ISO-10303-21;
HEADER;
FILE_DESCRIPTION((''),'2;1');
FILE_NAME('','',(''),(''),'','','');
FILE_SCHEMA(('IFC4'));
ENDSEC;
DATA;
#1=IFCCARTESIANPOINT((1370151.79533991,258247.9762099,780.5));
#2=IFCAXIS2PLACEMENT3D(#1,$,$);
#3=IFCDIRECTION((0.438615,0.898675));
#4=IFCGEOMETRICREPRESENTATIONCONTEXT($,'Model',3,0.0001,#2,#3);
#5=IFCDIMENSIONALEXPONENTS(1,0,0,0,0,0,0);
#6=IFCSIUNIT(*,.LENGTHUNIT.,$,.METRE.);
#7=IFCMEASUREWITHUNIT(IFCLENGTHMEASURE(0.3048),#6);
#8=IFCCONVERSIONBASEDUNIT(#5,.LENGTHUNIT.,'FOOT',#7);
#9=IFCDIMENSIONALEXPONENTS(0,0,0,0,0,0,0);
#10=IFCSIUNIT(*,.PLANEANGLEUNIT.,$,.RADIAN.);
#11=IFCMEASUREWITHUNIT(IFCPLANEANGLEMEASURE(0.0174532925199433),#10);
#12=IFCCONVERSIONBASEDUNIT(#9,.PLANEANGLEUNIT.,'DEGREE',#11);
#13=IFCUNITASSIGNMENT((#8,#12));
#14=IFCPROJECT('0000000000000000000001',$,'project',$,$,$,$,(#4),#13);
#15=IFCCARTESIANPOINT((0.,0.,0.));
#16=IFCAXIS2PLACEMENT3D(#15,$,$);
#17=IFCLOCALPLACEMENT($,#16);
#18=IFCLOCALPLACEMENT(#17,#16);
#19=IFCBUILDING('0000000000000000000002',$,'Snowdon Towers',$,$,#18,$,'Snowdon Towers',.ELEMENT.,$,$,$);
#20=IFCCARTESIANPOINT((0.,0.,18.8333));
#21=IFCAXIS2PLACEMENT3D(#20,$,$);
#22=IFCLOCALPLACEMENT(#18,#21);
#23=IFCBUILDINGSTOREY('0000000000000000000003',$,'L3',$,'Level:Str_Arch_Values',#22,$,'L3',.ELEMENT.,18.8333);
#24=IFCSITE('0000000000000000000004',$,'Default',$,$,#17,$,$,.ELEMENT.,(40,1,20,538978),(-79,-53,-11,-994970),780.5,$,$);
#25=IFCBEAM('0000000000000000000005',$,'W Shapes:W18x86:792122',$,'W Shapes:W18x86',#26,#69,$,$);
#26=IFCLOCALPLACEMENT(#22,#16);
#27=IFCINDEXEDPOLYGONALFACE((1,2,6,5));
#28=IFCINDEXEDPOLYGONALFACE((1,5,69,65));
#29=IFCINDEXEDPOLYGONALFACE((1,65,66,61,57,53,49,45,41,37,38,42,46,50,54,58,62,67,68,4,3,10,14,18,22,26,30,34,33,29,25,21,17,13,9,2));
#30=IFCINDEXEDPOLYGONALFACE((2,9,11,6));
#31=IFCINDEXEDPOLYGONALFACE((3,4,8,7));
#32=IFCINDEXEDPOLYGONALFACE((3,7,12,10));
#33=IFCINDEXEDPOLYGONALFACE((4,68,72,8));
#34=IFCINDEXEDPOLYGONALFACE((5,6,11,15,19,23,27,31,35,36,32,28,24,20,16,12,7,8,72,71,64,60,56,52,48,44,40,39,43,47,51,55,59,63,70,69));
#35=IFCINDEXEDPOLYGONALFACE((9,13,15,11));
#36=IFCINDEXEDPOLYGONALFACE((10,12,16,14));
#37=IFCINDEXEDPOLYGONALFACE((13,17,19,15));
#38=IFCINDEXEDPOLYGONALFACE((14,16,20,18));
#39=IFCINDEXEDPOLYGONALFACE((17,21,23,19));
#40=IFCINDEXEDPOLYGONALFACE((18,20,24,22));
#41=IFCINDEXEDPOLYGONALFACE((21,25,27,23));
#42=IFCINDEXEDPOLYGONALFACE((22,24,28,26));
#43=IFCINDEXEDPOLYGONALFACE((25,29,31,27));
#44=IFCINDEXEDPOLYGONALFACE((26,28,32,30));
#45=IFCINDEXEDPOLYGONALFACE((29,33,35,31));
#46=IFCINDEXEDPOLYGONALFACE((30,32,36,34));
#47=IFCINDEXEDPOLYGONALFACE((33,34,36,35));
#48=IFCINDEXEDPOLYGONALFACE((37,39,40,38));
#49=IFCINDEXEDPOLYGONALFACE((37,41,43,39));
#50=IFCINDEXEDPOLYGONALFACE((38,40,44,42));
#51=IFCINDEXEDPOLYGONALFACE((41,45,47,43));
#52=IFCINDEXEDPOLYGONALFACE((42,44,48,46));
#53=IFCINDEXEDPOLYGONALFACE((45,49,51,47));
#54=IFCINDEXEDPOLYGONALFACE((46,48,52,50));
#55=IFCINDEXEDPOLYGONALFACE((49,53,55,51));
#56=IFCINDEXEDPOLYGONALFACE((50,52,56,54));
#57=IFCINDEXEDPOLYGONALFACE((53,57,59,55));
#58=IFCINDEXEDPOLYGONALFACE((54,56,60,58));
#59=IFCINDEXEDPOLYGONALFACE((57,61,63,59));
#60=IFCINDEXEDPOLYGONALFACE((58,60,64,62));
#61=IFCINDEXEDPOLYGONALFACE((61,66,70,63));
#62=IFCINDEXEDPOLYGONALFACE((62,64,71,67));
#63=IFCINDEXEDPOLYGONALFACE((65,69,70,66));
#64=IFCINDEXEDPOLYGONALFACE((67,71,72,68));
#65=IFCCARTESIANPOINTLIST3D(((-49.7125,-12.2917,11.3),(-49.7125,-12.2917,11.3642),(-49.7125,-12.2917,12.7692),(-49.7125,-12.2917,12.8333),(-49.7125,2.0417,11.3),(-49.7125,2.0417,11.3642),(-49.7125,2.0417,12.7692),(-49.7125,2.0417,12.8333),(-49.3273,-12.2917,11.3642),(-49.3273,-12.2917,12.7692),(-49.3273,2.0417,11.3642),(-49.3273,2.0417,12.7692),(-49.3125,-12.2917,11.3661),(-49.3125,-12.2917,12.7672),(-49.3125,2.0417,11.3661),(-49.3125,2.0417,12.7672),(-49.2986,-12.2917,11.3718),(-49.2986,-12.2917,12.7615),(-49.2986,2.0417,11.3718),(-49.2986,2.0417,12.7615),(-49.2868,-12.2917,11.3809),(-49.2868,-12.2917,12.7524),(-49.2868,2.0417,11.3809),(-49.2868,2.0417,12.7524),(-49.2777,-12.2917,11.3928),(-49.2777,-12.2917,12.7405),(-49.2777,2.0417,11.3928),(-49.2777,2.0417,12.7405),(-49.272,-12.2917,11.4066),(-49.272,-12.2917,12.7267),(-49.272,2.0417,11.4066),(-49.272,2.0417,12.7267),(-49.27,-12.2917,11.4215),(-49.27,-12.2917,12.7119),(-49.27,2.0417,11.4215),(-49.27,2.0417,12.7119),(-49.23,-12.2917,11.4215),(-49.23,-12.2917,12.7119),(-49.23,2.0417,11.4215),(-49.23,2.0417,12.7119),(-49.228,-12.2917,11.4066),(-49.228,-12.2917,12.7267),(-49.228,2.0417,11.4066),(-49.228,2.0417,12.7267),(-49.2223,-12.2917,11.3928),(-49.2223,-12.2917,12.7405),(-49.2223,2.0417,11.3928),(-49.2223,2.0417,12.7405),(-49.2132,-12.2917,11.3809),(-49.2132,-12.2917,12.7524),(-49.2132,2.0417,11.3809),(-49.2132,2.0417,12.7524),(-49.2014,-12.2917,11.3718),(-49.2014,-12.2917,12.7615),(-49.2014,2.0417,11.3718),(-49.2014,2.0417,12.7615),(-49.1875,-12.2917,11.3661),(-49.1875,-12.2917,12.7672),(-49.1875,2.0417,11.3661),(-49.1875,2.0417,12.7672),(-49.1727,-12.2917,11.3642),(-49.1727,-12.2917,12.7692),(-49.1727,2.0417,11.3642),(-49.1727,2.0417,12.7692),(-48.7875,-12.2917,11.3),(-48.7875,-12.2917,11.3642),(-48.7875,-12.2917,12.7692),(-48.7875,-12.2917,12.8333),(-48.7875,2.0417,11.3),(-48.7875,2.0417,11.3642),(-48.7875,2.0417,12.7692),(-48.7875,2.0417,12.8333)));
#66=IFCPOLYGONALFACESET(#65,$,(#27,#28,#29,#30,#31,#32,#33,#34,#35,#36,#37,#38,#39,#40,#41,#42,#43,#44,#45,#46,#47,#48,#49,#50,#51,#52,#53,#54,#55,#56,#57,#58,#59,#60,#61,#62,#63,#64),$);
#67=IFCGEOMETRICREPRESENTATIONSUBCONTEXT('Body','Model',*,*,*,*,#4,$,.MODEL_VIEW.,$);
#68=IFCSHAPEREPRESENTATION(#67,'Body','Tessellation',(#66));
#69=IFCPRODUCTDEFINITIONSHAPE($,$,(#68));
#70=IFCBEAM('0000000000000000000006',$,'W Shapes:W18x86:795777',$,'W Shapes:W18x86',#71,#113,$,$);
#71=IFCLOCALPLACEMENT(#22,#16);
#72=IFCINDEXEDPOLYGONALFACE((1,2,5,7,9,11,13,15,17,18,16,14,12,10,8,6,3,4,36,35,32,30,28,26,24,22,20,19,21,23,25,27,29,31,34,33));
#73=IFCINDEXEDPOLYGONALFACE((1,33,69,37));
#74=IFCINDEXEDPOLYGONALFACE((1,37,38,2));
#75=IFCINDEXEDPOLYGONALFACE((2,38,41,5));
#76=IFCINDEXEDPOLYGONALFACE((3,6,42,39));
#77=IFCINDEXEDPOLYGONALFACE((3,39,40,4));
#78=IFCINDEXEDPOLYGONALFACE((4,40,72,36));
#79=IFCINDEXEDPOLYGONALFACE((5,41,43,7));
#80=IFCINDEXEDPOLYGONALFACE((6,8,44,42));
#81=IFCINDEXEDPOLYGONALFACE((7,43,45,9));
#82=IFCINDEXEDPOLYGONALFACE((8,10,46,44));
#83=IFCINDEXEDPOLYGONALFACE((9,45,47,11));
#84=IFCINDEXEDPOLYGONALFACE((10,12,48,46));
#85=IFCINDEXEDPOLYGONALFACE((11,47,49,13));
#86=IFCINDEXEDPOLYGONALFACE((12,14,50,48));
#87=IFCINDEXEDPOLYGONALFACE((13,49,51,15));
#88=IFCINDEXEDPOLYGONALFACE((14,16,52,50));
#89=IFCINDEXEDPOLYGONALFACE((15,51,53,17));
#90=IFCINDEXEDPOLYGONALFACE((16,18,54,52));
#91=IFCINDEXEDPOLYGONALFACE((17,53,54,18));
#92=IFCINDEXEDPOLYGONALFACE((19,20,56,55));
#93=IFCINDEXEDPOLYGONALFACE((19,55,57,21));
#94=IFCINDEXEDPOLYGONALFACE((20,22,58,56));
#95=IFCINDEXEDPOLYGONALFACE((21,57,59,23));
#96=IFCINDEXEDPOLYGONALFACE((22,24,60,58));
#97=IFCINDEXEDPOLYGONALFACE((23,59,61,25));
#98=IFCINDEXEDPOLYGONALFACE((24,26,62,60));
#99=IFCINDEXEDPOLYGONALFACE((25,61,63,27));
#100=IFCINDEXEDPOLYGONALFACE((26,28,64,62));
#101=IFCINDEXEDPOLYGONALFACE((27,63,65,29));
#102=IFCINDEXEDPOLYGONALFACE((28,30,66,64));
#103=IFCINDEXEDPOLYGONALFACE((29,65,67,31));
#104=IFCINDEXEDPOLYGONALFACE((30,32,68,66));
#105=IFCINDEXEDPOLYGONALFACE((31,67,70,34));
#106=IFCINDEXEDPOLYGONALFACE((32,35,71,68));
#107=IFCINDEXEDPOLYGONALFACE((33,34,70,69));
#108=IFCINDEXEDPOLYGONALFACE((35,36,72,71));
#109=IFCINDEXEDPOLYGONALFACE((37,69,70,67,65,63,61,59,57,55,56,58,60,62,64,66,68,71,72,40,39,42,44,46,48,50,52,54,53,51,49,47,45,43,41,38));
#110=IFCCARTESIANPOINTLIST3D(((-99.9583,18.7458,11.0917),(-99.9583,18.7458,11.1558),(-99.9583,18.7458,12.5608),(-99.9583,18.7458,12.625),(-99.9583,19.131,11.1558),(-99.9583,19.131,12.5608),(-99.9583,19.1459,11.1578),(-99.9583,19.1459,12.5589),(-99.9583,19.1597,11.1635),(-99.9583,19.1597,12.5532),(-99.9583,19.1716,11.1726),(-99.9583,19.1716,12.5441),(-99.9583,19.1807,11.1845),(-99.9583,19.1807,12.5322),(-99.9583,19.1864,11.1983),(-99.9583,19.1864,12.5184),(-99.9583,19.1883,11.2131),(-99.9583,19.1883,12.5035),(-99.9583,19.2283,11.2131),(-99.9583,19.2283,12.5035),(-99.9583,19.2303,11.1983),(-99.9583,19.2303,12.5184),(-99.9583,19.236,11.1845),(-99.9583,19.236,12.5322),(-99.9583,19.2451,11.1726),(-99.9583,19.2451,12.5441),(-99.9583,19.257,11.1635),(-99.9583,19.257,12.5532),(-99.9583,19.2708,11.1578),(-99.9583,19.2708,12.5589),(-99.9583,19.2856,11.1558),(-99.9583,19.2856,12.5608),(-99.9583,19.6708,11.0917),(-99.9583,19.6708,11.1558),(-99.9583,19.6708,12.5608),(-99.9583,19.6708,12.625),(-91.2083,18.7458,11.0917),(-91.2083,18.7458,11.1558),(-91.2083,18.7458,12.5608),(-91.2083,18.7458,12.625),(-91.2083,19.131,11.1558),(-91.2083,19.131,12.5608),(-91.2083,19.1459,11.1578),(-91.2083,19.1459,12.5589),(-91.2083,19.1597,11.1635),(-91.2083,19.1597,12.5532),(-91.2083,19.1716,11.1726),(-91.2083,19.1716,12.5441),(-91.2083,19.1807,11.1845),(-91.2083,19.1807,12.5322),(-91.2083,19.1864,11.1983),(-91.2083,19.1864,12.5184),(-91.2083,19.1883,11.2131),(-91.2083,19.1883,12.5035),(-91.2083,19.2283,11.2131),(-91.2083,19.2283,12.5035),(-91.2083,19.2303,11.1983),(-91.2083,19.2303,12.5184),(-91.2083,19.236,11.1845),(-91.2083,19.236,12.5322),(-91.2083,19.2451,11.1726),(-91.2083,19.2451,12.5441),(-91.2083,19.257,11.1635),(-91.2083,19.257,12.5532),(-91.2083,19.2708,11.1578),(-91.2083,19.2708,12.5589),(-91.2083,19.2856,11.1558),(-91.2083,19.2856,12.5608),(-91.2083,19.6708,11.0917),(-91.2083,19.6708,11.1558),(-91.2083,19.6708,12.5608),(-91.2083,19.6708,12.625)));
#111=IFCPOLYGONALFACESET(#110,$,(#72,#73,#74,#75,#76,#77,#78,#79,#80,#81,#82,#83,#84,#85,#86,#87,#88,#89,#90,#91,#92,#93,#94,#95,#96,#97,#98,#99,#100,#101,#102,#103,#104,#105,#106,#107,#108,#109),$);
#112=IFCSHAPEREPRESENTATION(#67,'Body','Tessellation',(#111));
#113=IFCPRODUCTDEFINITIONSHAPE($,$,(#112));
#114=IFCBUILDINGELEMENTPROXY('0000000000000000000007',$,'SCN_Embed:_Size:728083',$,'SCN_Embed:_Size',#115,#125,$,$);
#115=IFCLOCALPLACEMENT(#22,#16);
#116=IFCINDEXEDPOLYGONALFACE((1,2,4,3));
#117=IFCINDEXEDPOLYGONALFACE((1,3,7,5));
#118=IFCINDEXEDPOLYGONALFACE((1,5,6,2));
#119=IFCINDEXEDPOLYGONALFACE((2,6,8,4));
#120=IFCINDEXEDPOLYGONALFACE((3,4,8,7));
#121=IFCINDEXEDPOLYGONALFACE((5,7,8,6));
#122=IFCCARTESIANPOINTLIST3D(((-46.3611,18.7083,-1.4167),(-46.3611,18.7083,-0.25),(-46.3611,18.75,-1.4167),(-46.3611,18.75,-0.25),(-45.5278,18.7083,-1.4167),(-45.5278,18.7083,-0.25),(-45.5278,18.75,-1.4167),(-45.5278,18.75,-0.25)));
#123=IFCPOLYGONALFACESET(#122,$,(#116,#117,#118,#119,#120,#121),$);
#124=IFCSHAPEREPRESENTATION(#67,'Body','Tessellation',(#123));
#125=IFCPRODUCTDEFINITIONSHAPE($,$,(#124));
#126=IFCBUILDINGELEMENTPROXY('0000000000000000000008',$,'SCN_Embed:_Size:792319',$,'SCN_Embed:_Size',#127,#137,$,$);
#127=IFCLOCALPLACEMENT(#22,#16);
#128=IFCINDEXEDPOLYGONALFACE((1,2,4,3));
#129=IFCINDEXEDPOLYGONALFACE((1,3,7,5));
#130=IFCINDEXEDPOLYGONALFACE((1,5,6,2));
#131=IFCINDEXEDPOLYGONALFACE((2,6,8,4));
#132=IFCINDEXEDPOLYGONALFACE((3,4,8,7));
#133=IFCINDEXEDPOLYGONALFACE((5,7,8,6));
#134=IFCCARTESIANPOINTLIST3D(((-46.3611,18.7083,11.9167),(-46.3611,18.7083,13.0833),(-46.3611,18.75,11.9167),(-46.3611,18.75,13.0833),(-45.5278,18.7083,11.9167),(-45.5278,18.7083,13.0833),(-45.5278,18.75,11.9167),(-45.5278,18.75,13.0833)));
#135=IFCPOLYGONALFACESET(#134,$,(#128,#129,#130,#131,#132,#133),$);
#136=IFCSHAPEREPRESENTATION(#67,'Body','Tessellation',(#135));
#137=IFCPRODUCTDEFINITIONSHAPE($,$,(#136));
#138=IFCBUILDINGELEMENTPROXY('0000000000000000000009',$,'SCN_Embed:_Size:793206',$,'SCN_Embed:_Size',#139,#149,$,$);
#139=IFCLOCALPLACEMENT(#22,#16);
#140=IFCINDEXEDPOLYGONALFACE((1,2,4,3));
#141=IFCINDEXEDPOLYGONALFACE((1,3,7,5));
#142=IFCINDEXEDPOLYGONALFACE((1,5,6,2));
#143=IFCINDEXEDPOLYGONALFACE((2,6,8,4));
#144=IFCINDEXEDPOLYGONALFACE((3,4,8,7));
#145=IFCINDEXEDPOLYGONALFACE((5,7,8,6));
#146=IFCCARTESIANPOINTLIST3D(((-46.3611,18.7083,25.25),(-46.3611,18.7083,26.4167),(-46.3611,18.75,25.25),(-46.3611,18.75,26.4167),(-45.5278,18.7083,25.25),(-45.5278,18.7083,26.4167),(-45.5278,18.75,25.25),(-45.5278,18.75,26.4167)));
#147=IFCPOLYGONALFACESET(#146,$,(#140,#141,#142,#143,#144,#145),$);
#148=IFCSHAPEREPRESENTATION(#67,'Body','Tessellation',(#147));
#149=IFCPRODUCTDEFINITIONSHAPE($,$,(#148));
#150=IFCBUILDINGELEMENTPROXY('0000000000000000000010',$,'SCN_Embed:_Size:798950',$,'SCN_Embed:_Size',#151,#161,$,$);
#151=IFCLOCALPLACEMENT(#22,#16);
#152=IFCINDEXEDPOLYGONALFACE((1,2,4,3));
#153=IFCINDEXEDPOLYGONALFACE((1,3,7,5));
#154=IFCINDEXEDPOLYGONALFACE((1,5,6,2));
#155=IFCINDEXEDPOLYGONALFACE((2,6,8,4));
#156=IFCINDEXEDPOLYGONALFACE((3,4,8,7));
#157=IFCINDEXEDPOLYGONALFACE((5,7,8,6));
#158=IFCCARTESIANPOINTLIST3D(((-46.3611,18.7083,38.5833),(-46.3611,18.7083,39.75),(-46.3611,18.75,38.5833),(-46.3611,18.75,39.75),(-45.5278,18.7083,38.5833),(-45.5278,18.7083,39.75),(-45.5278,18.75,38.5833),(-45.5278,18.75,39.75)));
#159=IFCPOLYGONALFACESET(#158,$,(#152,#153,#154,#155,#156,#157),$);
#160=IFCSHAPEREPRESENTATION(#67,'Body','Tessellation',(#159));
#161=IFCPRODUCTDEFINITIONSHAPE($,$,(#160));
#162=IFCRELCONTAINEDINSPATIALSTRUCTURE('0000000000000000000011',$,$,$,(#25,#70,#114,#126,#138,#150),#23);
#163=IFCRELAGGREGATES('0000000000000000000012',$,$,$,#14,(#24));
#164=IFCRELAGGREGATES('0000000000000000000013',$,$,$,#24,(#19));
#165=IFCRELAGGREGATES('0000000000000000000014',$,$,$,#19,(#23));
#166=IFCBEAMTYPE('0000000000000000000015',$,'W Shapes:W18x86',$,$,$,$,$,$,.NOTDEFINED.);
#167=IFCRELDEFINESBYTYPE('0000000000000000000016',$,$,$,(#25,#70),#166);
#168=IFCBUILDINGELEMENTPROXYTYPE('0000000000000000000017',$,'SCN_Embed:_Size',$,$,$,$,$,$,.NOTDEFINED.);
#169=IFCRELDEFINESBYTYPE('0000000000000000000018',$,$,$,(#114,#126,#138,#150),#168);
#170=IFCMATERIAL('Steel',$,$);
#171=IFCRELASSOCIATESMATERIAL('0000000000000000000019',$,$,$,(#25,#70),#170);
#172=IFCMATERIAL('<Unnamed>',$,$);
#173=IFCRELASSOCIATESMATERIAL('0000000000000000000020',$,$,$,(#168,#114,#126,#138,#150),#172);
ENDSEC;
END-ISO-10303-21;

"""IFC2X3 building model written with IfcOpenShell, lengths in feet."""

from ifc_helpers import new_model, entity, si_unit, converted_unit, direction, frame, frame_2d, origin, place, context, subcontext, project, spatial, rectangle, i_section, extrude, source, transform, mapped, material, type_object, type_shapes, element, save


model = new_model("IFC2X3")

# Units and contexts
model_context = context("Model", 3, precision=0.0001, world=frame((1370151.79533991, 258247.9762099, 780.5)), true_north=direction((0.438615, 0.898675)))
body_context = subcontext(model_context, "Body", "Model", "MODEL_VIEW")
ifc_project = project(units=[converted_unit("LENGTHUNIT", "FOOT", entity("IfcLengthMeasure", 0.3048), si_unit("LENGTHUNIT", "METRE"), dimensions=[1, 0, 0, 0, 0, 0, 0]), converted_unit("PLANEANGLEUNIT", "DEGREE", entity("IfcPlaneAngleMeasure", 0.0174532925199433), si_unit("PLANEANGLEUNIT", "RADIAN"), dimensions=[0, 0, 0, 0, 0, 0, 0])], contexts=[model_context])

# Site, building, storey
site_placement = place(None, origin())
site = spatial("IfcSite", under=ifc_project, at=site_placement, Name="Default", CompositionType="ELEMENT", RefLatitude=(40, 1, 20, 538978), RefLongitude=(-79, -53, -11, -994970), RefElevation=780.5)
building_placement = place(site_placement, origin())
building = spatial("IfcBuilding", under=site, at=building_placement, Name="Snowdon Towers", LongName="Snowdon Towers", CompositionType="ELEMENT")
storey_placement = place(building_placement, frame((0.0, 0.0, 18.8333)))
storey = spatial("IfcBuildingStorey", under=building, at=storey_placement, Name="L3", ObjectType="Level:Str_Arch_Values", LongName="L3", CompositionType="ELEMENT", Elevation=18.8333)

# Shared definitions
ifc_material_1 = material(Name="Steel")

# Beams
beam_type_1 = type_object("IfcBeamType", Name="W Shapes:W18x86", PredefinedType="NOTDEFINED")
beam_1_placement = place(storey_placement, frame((-49.25, 2.5, 12.8333), z_axis=(0.0, 0.0, 1.0), x_axis=(0.0, -1.0, 0.0)))
element("IfcBeam", 1, at=beam_1_placement, inside=storey, type_object=beam_type_1, material=ifc_material_1, Name="W Shapes:W18x86:792122", ObjectType="W Shapes:W18x86", context=body_context, shape_type="SweptSolid", body=[
    extrude(i_section(OverallWidth=0.925, OverallDepth=1.5333, WebThickness=0.04, FlangeThickness=0.0642, FilletRadius=0.0573, at=frame_2d((0.0, 0.0), x_axis=(0.0, 1.0))), frame((0.4583, 0.0, -0.7667), z_axis=(1.0, 0.0, 0.0), x_axis=(0.0, 0.0, -1.0)), (0.0, 0.0, 1.0), 14.3333),
])
beam_2_placement = place(storey_placement, frame((-99.9583, 19.2083, 12.8333)))
element("IfcBeam", 2, at=beam_2_placement, inside=storey, type_object=beam_type_1, material=ifc_material_1, Name="W Shapes:W18x86:795777", ObjectType="W Shapes:W18x86", context=body_context, shape_type="SweptSolid", body=[
    extrude(i_section(OverallWidth=0.925, OverallDepth=1.5333, WebThickness=0.04, FlangeThickness=0.0642, FilletRadius=0.0573, at=frame_2d((0.0, 0.0), x_axis=(0.0, 1.0))), frame((0.0, 0.0, -0.975), z_axis=(1.0, 0.0, 0.0), x_axis=(0.0, 0.0, -1.0)), (0.0, 0.0, 1.0), 8.75),
])

# Building element proxies
ifc_material_2 = material(Name="<Unnamed>")
building_element_proxy_type_1 = type_object("IfcBuildingElementProxyType", Name="SCN_Embed:_Size", PredefinedType="NOTDEFINED", material=ifc_material_2)
shared_shape_1 = source(origin(), body_context, "Body", "SweptSolid", [
    extrude(rectangle(XDim=0.8333, YDim=1.1667, at=frame_2d((0.0, 0.0), x_axis=(1.0, 0.0))), frame((0.0, 0.0, -0.0417), z_axis=(0.0, 0.0, 1.0), x_axis=(-1.0, 0.0, 0.0)), (0.0, 0.0, 1.0), 0.0417),
])
type_shapes(building_element_proxy_type_1, [shared_shape_1])
for number, where, z_axis, x_axis, name in (
    (3, (-45.9444, 18.7083, -0.8333), (0.0, -1.0, 0.0), (1.0, 0.0, 0.0), "SCN_Embed:_Size:728083"),
    (4, (-45.9444, 18.7083, 12.5), (0.0, -1.0, 0.0), (1.0, 0.0, 0.0), "SCN_Embed:_Size:792319"),
    (5, (-45.9444, 18.7083, 25.8333), (0.0, -1.0, 0.0), (1.0, 0.0, 0.0), "SCN_Embed:_Size:793206"),
    (6, (-45.9444, 18.7083, 39.1667), (0.0, -1.0, 0.0), (1.0, 0.0, 0.0), "SCN_Embed:_Size:798950"),
):
    element("IfcBuildingElementProxy", number, at=place(storey_placement, frame(where, z_axis=z_axis, x_axis=x_axis)), inside=storey, type_object=building_element_proxy_type_1, material=ifc_material_2, Name=name, ObjectType="SCN_Embed:_Size", context=body_context, shape_type="MappedRepresentation", body=[
        mapped(shared_shape_1, transform((0.0, 0.0, 0.0), scale=1.0)),
    ])

save(model, "model.ifc")
